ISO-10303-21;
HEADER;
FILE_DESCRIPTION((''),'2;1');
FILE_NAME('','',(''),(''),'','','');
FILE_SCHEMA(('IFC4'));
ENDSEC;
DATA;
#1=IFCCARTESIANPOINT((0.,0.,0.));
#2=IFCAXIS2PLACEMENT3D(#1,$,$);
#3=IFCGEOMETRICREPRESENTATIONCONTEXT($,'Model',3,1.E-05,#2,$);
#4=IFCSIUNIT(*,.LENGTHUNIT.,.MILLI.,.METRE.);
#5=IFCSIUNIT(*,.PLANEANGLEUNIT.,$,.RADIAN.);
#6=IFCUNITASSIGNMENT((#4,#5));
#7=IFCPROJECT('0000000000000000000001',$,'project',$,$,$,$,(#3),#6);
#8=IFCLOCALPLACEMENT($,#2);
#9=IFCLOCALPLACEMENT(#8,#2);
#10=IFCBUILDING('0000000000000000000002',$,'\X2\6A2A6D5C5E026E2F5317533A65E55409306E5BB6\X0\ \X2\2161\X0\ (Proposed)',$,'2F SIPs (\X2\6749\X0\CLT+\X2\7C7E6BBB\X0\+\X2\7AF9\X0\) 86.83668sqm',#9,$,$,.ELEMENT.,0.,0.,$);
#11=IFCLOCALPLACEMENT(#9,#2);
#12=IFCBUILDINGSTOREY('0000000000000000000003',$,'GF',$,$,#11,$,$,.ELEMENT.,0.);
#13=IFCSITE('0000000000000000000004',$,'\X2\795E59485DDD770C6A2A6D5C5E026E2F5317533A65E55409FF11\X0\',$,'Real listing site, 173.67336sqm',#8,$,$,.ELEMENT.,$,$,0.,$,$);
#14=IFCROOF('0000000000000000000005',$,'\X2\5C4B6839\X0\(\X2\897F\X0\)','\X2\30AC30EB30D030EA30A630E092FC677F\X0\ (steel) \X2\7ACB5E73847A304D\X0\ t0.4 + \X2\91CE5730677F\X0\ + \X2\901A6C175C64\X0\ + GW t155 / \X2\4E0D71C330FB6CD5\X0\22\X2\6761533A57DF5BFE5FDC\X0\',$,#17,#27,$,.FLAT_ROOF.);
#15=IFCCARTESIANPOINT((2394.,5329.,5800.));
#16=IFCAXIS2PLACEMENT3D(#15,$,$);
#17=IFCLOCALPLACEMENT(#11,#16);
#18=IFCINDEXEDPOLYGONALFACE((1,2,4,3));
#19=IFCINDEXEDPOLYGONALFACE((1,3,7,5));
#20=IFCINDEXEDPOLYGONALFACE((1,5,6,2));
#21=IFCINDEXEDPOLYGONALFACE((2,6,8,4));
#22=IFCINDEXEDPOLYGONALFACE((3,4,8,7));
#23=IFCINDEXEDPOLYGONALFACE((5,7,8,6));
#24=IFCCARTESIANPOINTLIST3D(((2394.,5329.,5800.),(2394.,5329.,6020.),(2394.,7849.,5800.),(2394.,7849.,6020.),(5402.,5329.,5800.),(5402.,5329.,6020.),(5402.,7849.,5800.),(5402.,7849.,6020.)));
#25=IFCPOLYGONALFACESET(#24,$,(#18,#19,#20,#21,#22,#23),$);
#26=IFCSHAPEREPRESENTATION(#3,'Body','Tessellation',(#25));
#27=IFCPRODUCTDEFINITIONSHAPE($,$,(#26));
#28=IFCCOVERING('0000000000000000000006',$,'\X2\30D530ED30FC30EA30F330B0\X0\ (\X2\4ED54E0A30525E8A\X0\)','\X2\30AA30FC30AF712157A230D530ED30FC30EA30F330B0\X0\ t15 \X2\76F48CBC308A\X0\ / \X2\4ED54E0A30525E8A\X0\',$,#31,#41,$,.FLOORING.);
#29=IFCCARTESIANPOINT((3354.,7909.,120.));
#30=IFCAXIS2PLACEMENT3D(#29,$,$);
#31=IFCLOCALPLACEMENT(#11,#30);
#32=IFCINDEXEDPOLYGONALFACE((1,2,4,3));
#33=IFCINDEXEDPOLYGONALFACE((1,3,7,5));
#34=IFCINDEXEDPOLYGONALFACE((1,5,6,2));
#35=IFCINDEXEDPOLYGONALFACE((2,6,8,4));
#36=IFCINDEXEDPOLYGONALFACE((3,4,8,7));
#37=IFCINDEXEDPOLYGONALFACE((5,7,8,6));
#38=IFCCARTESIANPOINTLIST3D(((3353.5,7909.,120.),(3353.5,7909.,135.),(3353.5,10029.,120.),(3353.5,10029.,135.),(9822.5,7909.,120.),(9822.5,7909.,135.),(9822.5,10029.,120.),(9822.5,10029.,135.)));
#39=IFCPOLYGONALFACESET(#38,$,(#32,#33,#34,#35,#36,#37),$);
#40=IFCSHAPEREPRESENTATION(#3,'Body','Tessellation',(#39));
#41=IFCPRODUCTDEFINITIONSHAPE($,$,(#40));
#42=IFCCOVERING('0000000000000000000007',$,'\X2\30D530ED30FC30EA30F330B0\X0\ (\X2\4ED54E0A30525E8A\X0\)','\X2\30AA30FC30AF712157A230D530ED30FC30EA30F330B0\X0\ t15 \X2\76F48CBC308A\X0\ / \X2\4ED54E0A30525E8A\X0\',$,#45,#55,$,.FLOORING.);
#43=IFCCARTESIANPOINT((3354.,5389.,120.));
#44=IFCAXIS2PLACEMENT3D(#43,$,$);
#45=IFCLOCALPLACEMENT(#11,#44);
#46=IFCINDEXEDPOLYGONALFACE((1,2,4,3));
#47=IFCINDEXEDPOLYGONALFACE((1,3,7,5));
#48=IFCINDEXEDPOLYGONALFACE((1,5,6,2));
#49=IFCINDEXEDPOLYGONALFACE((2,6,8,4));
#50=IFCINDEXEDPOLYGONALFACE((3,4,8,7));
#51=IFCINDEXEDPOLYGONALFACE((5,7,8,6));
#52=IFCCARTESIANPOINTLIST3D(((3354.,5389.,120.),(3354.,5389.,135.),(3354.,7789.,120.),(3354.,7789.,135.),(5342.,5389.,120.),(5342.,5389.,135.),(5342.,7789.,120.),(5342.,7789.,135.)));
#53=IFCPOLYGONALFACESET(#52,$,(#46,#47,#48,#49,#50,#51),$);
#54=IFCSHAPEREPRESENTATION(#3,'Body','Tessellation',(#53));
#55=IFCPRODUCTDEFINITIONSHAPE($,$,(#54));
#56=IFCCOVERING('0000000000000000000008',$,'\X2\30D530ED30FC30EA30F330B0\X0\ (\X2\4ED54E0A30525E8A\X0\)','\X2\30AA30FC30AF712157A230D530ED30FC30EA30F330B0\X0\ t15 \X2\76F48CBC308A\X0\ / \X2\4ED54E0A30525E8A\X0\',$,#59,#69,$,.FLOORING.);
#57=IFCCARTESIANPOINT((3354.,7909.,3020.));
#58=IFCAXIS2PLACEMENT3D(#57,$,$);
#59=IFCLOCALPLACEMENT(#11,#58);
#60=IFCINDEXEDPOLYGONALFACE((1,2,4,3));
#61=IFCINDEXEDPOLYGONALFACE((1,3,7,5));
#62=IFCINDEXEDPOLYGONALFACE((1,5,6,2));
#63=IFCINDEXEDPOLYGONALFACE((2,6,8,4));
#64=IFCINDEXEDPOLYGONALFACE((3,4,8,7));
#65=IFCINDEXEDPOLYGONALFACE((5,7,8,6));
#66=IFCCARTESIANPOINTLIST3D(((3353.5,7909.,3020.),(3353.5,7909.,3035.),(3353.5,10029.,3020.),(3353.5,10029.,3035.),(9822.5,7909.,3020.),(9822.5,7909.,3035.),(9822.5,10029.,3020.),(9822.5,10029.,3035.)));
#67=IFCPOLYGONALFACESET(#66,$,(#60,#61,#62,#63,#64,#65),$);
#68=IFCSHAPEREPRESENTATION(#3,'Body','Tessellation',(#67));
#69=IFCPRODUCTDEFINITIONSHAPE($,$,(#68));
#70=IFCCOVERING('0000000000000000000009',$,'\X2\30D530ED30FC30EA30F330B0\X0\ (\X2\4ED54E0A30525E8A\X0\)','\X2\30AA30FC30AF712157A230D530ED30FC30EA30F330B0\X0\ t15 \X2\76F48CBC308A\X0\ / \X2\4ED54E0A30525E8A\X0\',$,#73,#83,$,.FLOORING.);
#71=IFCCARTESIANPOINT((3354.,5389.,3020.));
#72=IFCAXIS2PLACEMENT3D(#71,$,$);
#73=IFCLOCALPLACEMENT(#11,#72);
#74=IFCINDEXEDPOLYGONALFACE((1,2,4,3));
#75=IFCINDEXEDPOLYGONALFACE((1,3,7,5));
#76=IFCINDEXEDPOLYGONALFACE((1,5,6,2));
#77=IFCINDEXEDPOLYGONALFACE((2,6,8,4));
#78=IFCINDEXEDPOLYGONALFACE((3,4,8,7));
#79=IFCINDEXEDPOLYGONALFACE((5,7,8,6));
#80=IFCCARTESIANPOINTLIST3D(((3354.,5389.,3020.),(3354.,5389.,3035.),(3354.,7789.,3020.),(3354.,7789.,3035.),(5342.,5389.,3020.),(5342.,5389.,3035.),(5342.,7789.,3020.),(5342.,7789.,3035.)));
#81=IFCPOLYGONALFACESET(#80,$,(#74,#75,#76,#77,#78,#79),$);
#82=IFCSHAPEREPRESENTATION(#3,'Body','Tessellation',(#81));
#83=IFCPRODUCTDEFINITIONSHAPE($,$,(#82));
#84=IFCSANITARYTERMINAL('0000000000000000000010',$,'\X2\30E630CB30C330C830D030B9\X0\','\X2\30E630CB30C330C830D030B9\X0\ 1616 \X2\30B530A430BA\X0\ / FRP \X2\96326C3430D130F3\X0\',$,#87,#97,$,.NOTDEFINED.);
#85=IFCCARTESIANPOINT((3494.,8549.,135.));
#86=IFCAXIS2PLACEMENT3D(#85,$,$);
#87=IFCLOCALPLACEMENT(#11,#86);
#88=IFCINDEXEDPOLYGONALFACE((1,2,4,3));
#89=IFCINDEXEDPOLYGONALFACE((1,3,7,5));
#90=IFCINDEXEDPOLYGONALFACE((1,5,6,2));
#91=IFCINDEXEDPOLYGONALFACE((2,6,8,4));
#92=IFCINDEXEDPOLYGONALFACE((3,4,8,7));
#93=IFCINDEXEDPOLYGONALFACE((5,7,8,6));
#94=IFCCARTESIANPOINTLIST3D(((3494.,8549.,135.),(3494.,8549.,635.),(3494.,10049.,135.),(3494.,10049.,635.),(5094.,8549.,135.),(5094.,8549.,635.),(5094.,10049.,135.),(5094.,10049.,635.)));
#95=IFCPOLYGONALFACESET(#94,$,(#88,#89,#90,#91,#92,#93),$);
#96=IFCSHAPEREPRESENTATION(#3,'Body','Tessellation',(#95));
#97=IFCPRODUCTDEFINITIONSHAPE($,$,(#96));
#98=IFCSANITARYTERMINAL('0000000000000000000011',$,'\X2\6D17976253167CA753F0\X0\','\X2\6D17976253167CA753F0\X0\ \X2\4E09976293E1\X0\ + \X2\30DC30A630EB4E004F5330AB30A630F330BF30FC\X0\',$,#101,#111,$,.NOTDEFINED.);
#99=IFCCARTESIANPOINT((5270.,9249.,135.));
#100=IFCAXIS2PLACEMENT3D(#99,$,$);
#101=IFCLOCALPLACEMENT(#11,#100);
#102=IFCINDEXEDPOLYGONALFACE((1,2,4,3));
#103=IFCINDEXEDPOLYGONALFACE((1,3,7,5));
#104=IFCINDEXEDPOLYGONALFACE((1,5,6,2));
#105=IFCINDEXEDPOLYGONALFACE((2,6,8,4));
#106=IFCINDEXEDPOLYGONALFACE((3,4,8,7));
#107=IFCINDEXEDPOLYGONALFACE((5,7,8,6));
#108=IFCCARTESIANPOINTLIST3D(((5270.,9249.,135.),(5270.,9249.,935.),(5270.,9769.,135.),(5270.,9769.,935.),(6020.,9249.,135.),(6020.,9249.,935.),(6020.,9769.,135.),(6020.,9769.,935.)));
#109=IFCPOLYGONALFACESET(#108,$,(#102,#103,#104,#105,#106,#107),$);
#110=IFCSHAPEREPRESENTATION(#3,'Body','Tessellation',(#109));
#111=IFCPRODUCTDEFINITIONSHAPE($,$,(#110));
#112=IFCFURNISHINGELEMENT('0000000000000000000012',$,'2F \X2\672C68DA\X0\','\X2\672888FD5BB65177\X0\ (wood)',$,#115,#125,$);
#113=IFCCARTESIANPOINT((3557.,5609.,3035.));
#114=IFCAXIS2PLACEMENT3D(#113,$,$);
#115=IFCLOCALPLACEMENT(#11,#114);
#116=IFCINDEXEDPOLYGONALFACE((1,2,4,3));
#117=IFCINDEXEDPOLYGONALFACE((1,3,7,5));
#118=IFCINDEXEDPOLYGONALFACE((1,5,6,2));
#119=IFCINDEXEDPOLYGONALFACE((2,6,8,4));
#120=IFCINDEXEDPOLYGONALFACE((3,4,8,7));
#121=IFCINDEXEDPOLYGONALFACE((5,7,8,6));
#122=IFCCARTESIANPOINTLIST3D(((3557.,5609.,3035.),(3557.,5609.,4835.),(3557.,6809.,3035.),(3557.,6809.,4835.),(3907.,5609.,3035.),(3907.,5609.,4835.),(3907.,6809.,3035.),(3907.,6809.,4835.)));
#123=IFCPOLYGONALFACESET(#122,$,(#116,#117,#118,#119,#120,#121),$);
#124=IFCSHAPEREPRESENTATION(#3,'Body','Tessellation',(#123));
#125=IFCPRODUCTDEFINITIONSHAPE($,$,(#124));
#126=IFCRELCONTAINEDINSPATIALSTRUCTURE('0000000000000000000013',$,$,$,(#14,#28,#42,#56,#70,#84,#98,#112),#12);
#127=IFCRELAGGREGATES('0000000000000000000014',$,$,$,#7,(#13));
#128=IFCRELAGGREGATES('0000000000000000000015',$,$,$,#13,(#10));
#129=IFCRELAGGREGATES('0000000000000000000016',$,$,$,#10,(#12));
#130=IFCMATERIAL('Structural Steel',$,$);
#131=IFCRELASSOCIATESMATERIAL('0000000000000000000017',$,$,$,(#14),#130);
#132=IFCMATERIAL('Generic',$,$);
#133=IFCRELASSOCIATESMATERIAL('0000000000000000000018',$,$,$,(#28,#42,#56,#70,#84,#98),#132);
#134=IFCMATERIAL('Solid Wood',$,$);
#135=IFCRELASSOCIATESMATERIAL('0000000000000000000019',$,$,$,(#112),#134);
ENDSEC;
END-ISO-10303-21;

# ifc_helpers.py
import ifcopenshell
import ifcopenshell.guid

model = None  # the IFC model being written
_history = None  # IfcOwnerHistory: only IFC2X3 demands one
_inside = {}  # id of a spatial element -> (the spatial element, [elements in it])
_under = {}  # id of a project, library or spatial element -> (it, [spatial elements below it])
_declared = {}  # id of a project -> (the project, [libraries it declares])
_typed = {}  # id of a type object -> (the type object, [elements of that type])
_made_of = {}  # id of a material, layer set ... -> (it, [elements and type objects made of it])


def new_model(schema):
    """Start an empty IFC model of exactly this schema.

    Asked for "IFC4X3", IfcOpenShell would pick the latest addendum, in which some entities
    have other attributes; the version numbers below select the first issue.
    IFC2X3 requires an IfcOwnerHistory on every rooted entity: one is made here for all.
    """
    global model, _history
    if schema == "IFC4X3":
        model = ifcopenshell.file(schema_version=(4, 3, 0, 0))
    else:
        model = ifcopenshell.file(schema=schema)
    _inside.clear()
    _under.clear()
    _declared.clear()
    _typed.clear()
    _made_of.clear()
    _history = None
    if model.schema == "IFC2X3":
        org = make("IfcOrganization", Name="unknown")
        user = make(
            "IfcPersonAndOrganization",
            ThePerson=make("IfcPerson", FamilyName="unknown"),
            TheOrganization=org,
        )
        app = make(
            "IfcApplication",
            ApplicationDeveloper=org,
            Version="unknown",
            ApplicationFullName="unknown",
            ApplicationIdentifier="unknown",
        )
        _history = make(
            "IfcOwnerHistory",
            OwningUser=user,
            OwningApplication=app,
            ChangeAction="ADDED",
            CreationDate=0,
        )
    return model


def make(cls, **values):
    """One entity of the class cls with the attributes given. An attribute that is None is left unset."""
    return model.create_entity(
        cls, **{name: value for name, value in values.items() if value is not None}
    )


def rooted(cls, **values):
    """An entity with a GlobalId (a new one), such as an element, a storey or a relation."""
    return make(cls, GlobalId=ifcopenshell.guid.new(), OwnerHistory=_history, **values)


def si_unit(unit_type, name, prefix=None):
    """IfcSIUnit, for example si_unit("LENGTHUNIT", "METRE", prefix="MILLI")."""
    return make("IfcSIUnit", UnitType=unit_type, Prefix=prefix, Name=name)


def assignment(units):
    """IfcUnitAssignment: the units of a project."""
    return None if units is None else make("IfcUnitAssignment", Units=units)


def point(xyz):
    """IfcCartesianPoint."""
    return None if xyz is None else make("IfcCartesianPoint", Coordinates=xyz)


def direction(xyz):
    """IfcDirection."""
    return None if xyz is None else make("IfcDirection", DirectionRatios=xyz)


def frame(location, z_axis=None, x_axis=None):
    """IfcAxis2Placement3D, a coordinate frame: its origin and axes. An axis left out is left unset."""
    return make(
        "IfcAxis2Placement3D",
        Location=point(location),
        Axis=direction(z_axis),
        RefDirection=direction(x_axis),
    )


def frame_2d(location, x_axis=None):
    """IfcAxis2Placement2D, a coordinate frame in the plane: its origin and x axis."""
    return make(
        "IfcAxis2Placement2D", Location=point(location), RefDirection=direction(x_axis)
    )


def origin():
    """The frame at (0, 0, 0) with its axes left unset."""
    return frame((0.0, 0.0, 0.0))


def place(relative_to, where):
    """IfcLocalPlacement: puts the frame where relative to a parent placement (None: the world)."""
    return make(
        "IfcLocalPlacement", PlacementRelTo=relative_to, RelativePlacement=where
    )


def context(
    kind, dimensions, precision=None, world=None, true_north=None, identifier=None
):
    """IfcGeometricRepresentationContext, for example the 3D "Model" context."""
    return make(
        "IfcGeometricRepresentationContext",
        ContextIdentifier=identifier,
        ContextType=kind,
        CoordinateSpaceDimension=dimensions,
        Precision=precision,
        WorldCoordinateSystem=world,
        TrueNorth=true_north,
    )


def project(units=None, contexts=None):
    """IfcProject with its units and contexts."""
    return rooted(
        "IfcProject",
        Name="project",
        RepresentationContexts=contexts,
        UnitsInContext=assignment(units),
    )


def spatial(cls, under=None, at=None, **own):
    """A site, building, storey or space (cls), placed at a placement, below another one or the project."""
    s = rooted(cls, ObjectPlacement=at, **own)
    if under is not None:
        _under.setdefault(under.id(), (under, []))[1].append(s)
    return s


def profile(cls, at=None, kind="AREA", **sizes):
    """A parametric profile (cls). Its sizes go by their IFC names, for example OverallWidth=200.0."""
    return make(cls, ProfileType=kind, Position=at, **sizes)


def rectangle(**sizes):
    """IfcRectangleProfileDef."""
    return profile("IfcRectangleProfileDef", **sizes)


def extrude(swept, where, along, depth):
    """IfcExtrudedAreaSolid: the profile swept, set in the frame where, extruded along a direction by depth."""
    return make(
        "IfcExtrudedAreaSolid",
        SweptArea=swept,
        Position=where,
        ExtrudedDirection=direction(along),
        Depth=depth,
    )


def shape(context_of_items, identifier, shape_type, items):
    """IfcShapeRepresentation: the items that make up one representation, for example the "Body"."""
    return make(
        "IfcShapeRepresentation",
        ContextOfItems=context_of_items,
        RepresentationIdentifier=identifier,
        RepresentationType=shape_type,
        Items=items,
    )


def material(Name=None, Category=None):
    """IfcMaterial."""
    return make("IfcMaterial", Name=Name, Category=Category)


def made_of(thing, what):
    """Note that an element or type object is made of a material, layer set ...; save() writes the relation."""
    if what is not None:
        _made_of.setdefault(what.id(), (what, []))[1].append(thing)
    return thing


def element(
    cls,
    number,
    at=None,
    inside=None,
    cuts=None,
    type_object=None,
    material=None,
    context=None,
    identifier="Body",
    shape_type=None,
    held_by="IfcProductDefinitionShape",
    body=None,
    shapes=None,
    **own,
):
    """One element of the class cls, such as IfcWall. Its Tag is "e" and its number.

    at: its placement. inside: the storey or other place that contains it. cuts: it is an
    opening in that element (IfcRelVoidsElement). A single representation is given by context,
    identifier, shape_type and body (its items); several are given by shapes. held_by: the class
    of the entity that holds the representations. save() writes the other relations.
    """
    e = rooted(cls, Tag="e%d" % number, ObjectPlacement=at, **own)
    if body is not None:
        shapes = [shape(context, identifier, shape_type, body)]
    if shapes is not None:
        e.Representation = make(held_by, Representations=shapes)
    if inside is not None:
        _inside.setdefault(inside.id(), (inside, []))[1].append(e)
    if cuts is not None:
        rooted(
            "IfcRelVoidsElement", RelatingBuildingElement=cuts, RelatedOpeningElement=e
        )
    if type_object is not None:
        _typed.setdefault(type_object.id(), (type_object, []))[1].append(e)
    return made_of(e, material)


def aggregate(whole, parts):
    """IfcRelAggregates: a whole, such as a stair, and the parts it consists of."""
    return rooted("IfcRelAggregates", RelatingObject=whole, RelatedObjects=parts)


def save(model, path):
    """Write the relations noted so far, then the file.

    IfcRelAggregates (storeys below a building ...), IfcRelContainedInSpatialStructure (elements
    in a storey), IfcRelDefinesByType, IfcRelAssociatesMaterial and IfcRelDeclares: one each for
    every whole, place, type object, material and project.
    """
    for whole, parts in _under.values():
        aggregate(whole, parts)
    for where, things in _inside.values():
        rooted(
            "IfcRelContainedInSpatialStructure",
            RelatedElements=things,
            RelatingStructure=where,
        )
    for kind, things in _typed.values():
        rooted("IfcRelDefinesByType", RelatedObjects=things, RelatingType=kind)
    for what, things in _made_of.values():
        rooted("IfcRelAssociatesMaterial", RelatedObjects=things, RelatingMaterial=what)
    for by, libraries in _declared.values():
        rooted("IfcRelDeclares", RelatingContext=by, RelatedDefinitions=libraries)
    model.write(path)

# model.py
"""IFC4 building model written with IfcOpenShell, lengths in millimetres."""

from ifc_helpers import new_model, si_unit, frame, frame_2d, origin, place, context, project, spatial, rectangle, extrude, material, element, save


model = new_model("IFC4")

# Units and contexts
model_context = context("Model", 3, precision=1e-05, world=origin())
ifc_project = project(units=[si_unit("LENGTHUNIT", "METRE", prefix="MILLI"), si_unit("PLANEANGLEUNIT", "RADIAN")], contexts=[model_context])

# Site, building, storey
site_placement = place(None, origin())
site = spatial("IfcSite", under=ifc_project, at=site_placement, Name="神奈川県横浜市港北区日吉１", ObjectType="Real listing site, 173.67336sqm", CompositionType="ELEMENT", RefElevation=0.0)
building_placement = place(site_placement, origin())
building = spatial("IfcBuilding", under=site, at=building_placement, Name="横浜市港北区日吉の家 Ⅱ (Proposed)", ObjectType="2F SIPs (杉CLT+籾殻+竹) 86.83668sqm", CompositionType="ELEMENT", ElevationOfRefHeight=0.0, ElevationOfTerrain=0.0)
storey_placement = place(building_placement, origin())
storey = spatial("IfcBuildingStorey", under=building, at=storey_placement, Name="GF", CompositionType="ELEMENT", Elevation=0.0)

# Shared definitions
ifc_material_1 = material(Name="Solid Wood")

# Roof
ifc_material_2 = material(Name="Structural Steel")
roof_placement = place(storey_placement, frame((2394.0, 5329.0, 5800.0)))
element("IfcRoof", 1, at=roof_placement, inside=storey, material=ifc_material_2, Name="屋根(西)", Description="ガルバリウム鋼板 (steel) 立平葺き t0.4 + 野地板 + 通気層 + GW t155 / 不燃・法22条区域対応", PredefinedType="FLAT_ROOF", context=model_context, shape_type="SweptSolid", body=[
    extrude(rectangle(XDim=3008.0, YDim=2520.0, at=frame_2d((1504.0, 1260.0))), frame((2394.0, 5329.0, 5800.0)), (0.0, 0.0, 1.0), 220.0),
])

# Coverings
ifc_material_3 = material(Name="Generic")
covering_1_placement = place(storey_placement, frame((3354.0, 7909.0, 120.0)))
element("IfcCovering", 2, at=covering_1_placement, inside=storey, material=ifc_material_3, Name="フローリング (仕上げ床)", Description="オーク無垢フローリング t15 直貼り / 仕上げ床", PredefinedType="FLOORING", context=model_context, shape_type="SweptSolid", body=[
    extrude(rectangle(XDim=6469.0, YDim=2120.0, at=frame_2d((3234.0, 1060.0))), frame((3354.0, 7909.0, 120.0)), (0.0, 0.0, 1.0), 15.0),
])
covering_2_placement = place(storey_placement, frame((3354.0, 5389.0, 120.0)))
element("IfcCovering", 3, at=covering_2_placement, inside=storey, material=ifc_material_3, Name="フローリング (仕上げ床)", Description="オーク無垢フローリング t15 直貼り / 仕上げ床", PredefinedType="FLOORING", context=model_context, shape_type="SweptSolid", body=[
    extrude(rectangle(XDim=1988.0, YDim=2400.0, at=frame_2d((994.0, 1200.0))), frame((3354.0, 5389.0, 120.0)), (0.0, 0.0, 1.0), 15.0),
])
covering_3_placement = place(storey_placement, frame((3354.0, 7909.0, 3020.0)))
element("IfcCovering", 4, at=covering_3_placement, inside=storey, material=ifc_material_3, Name="フローリング (仕上げ床)", Description="オーク無垢フローリング t15 直貼り / 仕上げ床", PredefinedType="FLOORING", context=model_context, shape_type="SweptSolid", body=[
    extrude(rectangle(XDim=6469.0, YDim=2120.0, at=frame_2d((3234.0, 1060.0))), frame((3354.0, 7909.0, 3020.0)), (0.0, 0.0, 1.0), 15.0),
])
covering_4_placement = place(storey_placement, frame((3354.0, 5389.0, 3020.0)))
element("IfcCovering", 5, at=covering_4_placement, inside=storey, material=ifc_material_3, Name="フローリング (仕上げ床)", Description="オーク無垢フローリング t15 直貼り / 仕上げ床", PredefinedType="FLOORING", context=model_context, shape_type="SweptSolid", body=[
    extrude(rectangle(XDim=1988.0, YDim=2400.0, at=frame_2d((994.0, 1200.0))), frame((3354.0, 5389.0, 3020.0)), (0.0, 0.0, 1.0), 15.0),
])

# Sanitary terminals
sanitary_terminal_1_placement = place(storey_placement, frame((3494.0, 8549.0, 135.0)))
element("IfcSanitaryTerminal", 6, at=sanitary_terminal_1_placement, inside=storey, material=ifc_material_3, Name="ユニットバス", Description="ユニットバス 1616 サイズ / FRP 防水パン", PredefinedType="NOTDEFINED", context=model_context, shape_type="SweptSolid", body=[
    extrude(rectangle(XDim=1600.0, YDim=1500.0, at=frame_2d((800.0, 750.0))), frame((3494.0, 8549.0, 135.0)), (0.0, 0.0, 1.0), 500.0),
])
sanitary_terminal_2_placement = place(storey_placement, frame((5270.0, 9249.0, 135.0)))
element("IfcSanitaryTerminal", 7, at=sanitary_terminal_2_placement, inside=storey, material=ifc_material_3, Name="洗面化粧台", Description="洗面化粧台 三面鏡 + ボウル一体カウンター", PredefinedType="NOTDEFINED", context=model_context, shape_type="SweptSolid", body=[
    extrude(rectangle(XDim=750.0, YDim=520.0, at=frame_2d((375.0, 260.0))), frame((5270.0, 9249.0, 135.0)), (0.0, 0.0, 1.0), 800.0),
])

# Furnishing element
furnishing_placement = place(storey_placement, frame((3557.0, 5609.0, 3035.0)))
element("IfcFurnishingElement", 8, at=furnishing_placement, inside=storey, material=ifc_material_1, Name="2F 本棚", Description="木製家具 (wood)", context=model_context, shape_type="SweptSolid", body=[
    extrude(rectangle(XDim=350.0, YDim=1200.0, at=frame_2d((175.0, 600.0))), frame((3557.0, 5609.0, 3035.0)), (0.0, 0.0, 1.0), 1800.0),
])

save(model, "model.ifc")
